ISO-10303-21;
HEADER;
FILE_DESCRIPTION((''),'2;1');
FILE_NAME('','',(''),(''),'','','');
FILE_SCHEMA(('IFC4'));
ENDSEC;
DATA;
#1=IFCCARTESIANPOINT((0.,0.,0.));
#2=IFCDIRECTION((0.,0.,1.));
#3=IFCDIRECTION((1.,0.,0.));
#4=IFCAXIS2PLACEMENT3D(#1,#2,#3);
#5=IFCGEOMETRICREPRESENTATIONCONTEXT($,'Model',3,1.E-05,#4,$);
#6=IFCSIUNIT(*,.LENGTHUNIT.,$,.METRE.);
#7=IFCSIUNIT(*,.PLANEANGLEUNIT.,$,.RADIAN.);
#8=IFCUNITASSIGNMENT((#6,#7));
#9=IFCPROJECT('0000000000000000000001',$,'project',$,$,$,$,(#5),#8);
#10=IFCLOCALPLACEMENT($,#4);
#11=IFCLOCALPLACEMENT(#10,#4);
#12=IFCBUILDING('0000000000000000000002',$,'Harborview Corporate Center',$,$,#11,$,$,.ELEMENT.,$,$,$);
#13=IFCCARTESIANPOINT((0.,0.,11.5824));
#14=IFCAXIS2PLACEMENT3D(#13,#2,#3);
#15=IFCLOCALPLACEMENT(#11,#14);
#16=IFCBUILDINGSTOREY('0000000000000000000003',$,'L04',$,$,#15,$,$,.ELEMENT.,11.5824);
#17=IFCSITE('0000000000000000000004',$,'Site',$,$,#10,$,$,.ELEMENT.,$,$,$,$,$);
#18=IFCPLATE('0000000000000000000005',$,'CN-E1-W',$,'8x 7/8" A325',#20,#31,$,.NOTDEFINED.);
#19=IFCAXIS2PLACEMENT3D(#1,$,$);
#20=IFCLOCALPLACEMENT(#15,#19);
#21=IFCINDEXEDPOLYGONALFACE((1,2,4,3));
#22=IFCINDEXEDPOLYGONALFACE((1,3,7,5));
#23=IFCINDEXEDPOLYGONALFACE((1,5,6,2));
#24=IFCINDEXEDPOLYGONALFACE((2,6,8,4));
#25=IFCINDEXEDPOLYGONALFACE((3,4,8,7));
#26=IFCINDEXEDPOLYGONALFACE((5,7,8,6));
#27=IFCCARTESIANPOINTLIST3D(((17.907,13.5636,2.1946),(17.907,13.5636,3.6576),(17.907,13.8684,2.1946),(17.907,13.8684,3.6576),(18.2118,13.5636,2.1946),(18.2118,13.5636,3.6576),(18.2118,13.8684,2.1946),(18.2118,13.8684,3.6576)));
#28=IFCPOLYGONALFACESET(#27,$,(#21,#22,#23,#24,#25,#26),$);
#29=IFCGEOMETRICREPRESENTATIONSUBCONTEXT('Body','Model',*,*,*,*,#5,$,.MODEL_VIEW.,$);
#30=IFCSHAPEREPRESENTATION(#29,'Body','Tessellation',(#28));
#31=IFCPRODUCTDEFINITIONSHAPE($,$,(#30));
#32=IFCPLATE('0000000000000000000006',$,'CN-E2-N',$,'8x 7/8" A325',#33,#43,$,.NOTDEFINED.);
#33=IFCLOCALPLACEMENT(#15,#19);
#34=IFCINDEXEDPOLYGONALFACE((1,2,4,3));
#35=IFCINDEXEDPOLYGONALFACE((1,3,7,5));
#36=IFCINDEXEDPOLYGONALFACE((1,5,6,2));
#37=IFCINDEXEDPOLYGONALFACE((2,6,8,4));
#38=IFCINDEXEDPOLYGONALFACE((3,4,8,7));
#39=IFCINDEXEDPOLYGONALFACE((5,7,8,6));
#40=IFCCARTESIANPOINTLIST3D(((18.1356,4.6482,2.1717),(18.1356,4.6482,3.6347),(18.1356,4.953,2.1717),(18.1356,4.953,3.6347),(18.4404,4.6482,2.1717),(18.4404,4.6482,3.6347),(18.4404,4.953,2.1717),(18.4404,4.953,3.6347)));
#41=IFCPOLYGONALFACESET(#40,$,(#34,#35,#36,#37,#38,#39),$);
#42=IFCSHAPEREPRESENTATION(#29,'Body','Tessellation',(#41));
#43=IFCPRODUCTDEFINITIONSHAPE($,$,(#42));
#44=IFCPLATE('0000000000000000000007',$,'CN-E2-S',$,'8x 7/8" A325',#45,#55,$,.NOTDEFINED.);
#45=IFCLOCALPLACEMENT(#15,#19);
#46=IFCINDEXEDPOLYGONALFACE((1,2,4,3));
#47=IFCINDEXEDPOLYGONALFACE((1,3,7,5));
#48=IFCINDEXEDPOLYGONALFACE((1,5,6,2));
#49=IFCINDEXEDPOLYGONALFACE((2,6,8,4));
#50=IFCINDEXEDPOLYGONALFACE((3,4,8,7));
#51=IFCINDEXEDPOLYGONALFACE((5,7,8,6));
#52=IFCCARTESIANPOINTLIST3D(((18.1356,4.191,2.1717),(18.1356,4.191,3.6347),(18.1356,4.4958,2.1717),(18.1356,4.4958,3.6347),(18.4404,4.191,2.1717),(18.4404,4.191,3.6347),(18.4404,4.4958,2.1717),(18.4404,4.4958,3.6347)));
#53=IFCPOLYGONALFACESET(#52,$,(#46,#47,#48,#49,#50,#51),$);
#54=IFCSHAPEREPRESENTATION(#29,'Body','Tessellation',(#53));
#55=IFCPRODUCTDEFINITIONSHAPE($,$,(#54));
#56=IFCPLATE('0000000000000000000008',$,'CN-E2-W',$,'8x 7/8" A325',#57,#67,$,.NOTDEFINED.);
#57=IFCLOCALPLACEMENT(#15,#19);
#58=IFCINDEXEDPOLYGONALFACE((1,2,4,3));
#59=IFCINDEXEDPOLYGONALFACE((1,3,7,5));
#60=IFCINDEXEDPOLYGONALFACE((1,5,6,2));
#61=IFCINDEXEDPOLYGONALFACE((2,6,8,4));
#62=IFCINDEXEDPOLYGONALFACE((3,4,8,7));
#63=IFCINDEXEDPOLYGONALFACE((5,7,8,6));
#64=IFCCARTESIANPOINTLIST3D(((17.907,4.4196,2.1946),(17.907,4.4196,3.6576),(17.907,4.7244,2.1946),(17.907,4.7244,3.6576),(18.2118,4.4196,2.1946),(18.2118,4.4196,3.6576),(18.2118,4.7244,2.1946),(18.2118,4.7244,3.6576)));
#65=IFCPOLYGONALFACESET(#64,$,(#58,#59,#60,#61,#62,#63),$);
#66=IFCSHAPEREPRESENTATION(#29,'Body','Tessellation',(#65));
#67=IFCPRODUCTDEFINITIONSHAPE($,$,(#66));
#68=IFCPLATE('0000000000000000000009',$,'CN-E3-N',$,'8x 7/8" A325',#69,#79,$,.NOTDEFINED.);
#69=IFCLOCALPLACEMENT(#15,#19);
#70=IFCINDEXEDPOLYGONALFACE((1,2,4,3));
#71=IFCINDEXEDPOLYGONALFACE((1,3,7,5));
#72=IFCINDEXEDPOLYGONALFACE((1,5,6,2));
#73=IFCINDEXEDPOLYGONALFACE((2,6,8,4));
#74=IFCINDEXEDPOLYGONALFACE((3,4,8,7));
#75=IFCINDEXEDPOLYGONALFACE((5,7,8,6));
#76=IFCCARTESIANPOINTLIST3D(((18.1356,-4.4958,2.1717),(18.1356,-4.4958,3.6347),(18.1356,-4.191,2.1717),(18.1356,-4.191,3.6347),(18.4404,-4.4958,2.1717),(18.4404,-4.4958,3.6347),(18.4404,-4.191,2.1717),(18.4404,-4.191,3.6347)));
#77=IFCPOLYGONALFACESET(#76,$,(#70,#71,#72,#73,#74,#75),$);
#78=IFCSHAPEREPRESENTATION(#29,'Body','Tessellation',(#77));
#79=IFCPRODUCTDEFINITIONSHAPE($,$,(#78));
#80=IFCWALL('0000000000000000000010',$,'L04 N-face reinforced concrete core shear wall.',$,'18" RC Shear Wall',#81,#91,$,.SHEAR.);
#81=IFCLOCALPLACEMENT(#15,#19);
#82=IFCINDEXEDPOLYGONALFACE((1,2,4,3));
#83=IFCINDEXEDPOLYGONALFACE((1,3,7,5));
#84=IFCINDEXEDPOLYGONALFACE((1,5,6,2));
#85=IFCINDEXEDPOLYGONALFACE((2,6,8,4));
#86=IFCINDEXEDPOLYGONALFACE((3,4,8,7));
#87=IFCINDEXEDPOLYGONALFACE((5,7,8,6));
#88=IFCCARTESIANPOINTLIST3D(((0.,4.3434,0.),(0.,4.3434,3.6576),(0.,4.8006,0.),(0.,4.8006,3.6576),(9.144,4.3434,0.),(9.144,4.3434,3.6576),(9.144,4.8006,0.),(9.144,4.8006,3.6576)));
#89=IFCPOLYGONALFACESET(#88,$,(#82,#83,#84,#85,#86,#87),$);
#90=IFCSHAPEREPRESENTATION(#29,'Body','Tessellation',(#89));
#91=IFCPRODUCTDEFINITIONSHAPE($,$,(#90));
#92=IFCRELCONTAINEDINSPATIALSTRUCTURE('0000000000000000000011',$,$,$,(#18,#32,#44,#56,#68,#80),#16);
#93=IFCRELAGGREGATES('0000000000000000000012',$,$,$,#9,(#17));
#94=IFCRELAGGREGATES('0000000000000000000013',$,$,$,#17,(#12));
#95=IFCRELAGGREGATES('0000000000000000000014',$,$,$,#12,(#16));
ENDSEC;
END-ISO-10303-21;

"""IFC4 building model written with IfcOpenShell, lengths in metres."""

from ifc_helpers import new_model, si_unit, frame, origin_with_axes, place, context, subcontext, project, spatial, rectangle, extrude, element, save


model = new_model("IFC4")

# Units and contexts
model_context = context("Model", 3, precision=1e-05, world=origin_with_axes())
body_context = subcontext(model_context, "Body", "Model", "MODEL_VIEW")
ifc_project = project(units=[si_unit("LENGTHUNIT", "METRE"), si_unit("PLANEANGLEUNIT", "RADIAN")], contexts=[model_context])

# Site, building, storey
site_placement = place(None, origin_with_axes())
site = spatial("IfcSite", under=ifc_project, at=site_placement, Name="Site", CompositionType="ELEMENT")
building_placement = place(site_placement, origin_with_axes())
building = spatial("IfcBuilding", under=site, at=building_placement, Name="Harborview Corporate Center", CompositionType="ELEMENT")
storey_placement = place(building_placement, frame((0.0, 0.0, 11.5824), z_axis=(0.0, 0.0, 1.0), x_axis=(1.0, 0.0, 0.0)))
storey = spatial("IfcBuildingStorey", under=building, at=storey_placement, Name="L04", CompositionType="ELEMENT", Elevation=11.5824)

# Plates
for number, where, z_axis, x_axis, name in (
    (1, (18.0594, 13.716, 2.1946), (0.0, 0.0, 1.0), (1.0, 0.0, 0.0), "CN-E1-W"),
    (2, (18.288, 4.8006, 2.1717), (0.0, 0.0, 1.0), (1.0, 0.0, 0.0), "CN-E2-N"),
    (3, (18.288, 4.3434, 2.1717), (0.0, 0.0, 1.0), (1.0, 0.0, 0.0), "CN-E2-S"),
    (4, (18.0594, 4.572, 2.1946), (0.0, 0.0, 1.0), (1.0, 0.0, 0.0), "CN-E2-W"),
    (5, (18.288, -4.3434, 2.1717), (0.0, 0.0, 1.0), (1.0, 0.0, 0.0), "CN-E3-N"),
):
    element("IfcPlate", number, at=place(storey_placement, frame(where, z_axis=z_axis, x_axis=x_axis)), inside=storey, Name=name, ObjectType="8x 7/8\" A325", PredefinedType="NOTDEFINED", context=body_context, shape_type="SweptSolid", body=[
        extrude(rectangle(XDim=0.3048, YDim=0.3048), origin_with_axes(), (0.0, 0.0, 1.0), 1.463),
    ])

# Wall
wall_placement = place(storey_placement, frame((4.572, 4.572, 0.0), z_axis=(0.0, 0.0, 1.0), x_axis=(1.0, 0.0, 0.0)))
element("IfcWall", 6, at=wall_placement, inside=storey, Name="L04 N-face reinforced concrete core shear wall.", ObjectType="18\" RC Shear Wall", PredefinedType="SHEAR", context=body_context, shape_type="SweptSolid", body=[
    extrude(rectangle(XDim=9.144, YDim=0.4572), origin_with_axes(), (0.0, 0.0, 1.0), 3.6576),
])

save(model, "model.ifc")
